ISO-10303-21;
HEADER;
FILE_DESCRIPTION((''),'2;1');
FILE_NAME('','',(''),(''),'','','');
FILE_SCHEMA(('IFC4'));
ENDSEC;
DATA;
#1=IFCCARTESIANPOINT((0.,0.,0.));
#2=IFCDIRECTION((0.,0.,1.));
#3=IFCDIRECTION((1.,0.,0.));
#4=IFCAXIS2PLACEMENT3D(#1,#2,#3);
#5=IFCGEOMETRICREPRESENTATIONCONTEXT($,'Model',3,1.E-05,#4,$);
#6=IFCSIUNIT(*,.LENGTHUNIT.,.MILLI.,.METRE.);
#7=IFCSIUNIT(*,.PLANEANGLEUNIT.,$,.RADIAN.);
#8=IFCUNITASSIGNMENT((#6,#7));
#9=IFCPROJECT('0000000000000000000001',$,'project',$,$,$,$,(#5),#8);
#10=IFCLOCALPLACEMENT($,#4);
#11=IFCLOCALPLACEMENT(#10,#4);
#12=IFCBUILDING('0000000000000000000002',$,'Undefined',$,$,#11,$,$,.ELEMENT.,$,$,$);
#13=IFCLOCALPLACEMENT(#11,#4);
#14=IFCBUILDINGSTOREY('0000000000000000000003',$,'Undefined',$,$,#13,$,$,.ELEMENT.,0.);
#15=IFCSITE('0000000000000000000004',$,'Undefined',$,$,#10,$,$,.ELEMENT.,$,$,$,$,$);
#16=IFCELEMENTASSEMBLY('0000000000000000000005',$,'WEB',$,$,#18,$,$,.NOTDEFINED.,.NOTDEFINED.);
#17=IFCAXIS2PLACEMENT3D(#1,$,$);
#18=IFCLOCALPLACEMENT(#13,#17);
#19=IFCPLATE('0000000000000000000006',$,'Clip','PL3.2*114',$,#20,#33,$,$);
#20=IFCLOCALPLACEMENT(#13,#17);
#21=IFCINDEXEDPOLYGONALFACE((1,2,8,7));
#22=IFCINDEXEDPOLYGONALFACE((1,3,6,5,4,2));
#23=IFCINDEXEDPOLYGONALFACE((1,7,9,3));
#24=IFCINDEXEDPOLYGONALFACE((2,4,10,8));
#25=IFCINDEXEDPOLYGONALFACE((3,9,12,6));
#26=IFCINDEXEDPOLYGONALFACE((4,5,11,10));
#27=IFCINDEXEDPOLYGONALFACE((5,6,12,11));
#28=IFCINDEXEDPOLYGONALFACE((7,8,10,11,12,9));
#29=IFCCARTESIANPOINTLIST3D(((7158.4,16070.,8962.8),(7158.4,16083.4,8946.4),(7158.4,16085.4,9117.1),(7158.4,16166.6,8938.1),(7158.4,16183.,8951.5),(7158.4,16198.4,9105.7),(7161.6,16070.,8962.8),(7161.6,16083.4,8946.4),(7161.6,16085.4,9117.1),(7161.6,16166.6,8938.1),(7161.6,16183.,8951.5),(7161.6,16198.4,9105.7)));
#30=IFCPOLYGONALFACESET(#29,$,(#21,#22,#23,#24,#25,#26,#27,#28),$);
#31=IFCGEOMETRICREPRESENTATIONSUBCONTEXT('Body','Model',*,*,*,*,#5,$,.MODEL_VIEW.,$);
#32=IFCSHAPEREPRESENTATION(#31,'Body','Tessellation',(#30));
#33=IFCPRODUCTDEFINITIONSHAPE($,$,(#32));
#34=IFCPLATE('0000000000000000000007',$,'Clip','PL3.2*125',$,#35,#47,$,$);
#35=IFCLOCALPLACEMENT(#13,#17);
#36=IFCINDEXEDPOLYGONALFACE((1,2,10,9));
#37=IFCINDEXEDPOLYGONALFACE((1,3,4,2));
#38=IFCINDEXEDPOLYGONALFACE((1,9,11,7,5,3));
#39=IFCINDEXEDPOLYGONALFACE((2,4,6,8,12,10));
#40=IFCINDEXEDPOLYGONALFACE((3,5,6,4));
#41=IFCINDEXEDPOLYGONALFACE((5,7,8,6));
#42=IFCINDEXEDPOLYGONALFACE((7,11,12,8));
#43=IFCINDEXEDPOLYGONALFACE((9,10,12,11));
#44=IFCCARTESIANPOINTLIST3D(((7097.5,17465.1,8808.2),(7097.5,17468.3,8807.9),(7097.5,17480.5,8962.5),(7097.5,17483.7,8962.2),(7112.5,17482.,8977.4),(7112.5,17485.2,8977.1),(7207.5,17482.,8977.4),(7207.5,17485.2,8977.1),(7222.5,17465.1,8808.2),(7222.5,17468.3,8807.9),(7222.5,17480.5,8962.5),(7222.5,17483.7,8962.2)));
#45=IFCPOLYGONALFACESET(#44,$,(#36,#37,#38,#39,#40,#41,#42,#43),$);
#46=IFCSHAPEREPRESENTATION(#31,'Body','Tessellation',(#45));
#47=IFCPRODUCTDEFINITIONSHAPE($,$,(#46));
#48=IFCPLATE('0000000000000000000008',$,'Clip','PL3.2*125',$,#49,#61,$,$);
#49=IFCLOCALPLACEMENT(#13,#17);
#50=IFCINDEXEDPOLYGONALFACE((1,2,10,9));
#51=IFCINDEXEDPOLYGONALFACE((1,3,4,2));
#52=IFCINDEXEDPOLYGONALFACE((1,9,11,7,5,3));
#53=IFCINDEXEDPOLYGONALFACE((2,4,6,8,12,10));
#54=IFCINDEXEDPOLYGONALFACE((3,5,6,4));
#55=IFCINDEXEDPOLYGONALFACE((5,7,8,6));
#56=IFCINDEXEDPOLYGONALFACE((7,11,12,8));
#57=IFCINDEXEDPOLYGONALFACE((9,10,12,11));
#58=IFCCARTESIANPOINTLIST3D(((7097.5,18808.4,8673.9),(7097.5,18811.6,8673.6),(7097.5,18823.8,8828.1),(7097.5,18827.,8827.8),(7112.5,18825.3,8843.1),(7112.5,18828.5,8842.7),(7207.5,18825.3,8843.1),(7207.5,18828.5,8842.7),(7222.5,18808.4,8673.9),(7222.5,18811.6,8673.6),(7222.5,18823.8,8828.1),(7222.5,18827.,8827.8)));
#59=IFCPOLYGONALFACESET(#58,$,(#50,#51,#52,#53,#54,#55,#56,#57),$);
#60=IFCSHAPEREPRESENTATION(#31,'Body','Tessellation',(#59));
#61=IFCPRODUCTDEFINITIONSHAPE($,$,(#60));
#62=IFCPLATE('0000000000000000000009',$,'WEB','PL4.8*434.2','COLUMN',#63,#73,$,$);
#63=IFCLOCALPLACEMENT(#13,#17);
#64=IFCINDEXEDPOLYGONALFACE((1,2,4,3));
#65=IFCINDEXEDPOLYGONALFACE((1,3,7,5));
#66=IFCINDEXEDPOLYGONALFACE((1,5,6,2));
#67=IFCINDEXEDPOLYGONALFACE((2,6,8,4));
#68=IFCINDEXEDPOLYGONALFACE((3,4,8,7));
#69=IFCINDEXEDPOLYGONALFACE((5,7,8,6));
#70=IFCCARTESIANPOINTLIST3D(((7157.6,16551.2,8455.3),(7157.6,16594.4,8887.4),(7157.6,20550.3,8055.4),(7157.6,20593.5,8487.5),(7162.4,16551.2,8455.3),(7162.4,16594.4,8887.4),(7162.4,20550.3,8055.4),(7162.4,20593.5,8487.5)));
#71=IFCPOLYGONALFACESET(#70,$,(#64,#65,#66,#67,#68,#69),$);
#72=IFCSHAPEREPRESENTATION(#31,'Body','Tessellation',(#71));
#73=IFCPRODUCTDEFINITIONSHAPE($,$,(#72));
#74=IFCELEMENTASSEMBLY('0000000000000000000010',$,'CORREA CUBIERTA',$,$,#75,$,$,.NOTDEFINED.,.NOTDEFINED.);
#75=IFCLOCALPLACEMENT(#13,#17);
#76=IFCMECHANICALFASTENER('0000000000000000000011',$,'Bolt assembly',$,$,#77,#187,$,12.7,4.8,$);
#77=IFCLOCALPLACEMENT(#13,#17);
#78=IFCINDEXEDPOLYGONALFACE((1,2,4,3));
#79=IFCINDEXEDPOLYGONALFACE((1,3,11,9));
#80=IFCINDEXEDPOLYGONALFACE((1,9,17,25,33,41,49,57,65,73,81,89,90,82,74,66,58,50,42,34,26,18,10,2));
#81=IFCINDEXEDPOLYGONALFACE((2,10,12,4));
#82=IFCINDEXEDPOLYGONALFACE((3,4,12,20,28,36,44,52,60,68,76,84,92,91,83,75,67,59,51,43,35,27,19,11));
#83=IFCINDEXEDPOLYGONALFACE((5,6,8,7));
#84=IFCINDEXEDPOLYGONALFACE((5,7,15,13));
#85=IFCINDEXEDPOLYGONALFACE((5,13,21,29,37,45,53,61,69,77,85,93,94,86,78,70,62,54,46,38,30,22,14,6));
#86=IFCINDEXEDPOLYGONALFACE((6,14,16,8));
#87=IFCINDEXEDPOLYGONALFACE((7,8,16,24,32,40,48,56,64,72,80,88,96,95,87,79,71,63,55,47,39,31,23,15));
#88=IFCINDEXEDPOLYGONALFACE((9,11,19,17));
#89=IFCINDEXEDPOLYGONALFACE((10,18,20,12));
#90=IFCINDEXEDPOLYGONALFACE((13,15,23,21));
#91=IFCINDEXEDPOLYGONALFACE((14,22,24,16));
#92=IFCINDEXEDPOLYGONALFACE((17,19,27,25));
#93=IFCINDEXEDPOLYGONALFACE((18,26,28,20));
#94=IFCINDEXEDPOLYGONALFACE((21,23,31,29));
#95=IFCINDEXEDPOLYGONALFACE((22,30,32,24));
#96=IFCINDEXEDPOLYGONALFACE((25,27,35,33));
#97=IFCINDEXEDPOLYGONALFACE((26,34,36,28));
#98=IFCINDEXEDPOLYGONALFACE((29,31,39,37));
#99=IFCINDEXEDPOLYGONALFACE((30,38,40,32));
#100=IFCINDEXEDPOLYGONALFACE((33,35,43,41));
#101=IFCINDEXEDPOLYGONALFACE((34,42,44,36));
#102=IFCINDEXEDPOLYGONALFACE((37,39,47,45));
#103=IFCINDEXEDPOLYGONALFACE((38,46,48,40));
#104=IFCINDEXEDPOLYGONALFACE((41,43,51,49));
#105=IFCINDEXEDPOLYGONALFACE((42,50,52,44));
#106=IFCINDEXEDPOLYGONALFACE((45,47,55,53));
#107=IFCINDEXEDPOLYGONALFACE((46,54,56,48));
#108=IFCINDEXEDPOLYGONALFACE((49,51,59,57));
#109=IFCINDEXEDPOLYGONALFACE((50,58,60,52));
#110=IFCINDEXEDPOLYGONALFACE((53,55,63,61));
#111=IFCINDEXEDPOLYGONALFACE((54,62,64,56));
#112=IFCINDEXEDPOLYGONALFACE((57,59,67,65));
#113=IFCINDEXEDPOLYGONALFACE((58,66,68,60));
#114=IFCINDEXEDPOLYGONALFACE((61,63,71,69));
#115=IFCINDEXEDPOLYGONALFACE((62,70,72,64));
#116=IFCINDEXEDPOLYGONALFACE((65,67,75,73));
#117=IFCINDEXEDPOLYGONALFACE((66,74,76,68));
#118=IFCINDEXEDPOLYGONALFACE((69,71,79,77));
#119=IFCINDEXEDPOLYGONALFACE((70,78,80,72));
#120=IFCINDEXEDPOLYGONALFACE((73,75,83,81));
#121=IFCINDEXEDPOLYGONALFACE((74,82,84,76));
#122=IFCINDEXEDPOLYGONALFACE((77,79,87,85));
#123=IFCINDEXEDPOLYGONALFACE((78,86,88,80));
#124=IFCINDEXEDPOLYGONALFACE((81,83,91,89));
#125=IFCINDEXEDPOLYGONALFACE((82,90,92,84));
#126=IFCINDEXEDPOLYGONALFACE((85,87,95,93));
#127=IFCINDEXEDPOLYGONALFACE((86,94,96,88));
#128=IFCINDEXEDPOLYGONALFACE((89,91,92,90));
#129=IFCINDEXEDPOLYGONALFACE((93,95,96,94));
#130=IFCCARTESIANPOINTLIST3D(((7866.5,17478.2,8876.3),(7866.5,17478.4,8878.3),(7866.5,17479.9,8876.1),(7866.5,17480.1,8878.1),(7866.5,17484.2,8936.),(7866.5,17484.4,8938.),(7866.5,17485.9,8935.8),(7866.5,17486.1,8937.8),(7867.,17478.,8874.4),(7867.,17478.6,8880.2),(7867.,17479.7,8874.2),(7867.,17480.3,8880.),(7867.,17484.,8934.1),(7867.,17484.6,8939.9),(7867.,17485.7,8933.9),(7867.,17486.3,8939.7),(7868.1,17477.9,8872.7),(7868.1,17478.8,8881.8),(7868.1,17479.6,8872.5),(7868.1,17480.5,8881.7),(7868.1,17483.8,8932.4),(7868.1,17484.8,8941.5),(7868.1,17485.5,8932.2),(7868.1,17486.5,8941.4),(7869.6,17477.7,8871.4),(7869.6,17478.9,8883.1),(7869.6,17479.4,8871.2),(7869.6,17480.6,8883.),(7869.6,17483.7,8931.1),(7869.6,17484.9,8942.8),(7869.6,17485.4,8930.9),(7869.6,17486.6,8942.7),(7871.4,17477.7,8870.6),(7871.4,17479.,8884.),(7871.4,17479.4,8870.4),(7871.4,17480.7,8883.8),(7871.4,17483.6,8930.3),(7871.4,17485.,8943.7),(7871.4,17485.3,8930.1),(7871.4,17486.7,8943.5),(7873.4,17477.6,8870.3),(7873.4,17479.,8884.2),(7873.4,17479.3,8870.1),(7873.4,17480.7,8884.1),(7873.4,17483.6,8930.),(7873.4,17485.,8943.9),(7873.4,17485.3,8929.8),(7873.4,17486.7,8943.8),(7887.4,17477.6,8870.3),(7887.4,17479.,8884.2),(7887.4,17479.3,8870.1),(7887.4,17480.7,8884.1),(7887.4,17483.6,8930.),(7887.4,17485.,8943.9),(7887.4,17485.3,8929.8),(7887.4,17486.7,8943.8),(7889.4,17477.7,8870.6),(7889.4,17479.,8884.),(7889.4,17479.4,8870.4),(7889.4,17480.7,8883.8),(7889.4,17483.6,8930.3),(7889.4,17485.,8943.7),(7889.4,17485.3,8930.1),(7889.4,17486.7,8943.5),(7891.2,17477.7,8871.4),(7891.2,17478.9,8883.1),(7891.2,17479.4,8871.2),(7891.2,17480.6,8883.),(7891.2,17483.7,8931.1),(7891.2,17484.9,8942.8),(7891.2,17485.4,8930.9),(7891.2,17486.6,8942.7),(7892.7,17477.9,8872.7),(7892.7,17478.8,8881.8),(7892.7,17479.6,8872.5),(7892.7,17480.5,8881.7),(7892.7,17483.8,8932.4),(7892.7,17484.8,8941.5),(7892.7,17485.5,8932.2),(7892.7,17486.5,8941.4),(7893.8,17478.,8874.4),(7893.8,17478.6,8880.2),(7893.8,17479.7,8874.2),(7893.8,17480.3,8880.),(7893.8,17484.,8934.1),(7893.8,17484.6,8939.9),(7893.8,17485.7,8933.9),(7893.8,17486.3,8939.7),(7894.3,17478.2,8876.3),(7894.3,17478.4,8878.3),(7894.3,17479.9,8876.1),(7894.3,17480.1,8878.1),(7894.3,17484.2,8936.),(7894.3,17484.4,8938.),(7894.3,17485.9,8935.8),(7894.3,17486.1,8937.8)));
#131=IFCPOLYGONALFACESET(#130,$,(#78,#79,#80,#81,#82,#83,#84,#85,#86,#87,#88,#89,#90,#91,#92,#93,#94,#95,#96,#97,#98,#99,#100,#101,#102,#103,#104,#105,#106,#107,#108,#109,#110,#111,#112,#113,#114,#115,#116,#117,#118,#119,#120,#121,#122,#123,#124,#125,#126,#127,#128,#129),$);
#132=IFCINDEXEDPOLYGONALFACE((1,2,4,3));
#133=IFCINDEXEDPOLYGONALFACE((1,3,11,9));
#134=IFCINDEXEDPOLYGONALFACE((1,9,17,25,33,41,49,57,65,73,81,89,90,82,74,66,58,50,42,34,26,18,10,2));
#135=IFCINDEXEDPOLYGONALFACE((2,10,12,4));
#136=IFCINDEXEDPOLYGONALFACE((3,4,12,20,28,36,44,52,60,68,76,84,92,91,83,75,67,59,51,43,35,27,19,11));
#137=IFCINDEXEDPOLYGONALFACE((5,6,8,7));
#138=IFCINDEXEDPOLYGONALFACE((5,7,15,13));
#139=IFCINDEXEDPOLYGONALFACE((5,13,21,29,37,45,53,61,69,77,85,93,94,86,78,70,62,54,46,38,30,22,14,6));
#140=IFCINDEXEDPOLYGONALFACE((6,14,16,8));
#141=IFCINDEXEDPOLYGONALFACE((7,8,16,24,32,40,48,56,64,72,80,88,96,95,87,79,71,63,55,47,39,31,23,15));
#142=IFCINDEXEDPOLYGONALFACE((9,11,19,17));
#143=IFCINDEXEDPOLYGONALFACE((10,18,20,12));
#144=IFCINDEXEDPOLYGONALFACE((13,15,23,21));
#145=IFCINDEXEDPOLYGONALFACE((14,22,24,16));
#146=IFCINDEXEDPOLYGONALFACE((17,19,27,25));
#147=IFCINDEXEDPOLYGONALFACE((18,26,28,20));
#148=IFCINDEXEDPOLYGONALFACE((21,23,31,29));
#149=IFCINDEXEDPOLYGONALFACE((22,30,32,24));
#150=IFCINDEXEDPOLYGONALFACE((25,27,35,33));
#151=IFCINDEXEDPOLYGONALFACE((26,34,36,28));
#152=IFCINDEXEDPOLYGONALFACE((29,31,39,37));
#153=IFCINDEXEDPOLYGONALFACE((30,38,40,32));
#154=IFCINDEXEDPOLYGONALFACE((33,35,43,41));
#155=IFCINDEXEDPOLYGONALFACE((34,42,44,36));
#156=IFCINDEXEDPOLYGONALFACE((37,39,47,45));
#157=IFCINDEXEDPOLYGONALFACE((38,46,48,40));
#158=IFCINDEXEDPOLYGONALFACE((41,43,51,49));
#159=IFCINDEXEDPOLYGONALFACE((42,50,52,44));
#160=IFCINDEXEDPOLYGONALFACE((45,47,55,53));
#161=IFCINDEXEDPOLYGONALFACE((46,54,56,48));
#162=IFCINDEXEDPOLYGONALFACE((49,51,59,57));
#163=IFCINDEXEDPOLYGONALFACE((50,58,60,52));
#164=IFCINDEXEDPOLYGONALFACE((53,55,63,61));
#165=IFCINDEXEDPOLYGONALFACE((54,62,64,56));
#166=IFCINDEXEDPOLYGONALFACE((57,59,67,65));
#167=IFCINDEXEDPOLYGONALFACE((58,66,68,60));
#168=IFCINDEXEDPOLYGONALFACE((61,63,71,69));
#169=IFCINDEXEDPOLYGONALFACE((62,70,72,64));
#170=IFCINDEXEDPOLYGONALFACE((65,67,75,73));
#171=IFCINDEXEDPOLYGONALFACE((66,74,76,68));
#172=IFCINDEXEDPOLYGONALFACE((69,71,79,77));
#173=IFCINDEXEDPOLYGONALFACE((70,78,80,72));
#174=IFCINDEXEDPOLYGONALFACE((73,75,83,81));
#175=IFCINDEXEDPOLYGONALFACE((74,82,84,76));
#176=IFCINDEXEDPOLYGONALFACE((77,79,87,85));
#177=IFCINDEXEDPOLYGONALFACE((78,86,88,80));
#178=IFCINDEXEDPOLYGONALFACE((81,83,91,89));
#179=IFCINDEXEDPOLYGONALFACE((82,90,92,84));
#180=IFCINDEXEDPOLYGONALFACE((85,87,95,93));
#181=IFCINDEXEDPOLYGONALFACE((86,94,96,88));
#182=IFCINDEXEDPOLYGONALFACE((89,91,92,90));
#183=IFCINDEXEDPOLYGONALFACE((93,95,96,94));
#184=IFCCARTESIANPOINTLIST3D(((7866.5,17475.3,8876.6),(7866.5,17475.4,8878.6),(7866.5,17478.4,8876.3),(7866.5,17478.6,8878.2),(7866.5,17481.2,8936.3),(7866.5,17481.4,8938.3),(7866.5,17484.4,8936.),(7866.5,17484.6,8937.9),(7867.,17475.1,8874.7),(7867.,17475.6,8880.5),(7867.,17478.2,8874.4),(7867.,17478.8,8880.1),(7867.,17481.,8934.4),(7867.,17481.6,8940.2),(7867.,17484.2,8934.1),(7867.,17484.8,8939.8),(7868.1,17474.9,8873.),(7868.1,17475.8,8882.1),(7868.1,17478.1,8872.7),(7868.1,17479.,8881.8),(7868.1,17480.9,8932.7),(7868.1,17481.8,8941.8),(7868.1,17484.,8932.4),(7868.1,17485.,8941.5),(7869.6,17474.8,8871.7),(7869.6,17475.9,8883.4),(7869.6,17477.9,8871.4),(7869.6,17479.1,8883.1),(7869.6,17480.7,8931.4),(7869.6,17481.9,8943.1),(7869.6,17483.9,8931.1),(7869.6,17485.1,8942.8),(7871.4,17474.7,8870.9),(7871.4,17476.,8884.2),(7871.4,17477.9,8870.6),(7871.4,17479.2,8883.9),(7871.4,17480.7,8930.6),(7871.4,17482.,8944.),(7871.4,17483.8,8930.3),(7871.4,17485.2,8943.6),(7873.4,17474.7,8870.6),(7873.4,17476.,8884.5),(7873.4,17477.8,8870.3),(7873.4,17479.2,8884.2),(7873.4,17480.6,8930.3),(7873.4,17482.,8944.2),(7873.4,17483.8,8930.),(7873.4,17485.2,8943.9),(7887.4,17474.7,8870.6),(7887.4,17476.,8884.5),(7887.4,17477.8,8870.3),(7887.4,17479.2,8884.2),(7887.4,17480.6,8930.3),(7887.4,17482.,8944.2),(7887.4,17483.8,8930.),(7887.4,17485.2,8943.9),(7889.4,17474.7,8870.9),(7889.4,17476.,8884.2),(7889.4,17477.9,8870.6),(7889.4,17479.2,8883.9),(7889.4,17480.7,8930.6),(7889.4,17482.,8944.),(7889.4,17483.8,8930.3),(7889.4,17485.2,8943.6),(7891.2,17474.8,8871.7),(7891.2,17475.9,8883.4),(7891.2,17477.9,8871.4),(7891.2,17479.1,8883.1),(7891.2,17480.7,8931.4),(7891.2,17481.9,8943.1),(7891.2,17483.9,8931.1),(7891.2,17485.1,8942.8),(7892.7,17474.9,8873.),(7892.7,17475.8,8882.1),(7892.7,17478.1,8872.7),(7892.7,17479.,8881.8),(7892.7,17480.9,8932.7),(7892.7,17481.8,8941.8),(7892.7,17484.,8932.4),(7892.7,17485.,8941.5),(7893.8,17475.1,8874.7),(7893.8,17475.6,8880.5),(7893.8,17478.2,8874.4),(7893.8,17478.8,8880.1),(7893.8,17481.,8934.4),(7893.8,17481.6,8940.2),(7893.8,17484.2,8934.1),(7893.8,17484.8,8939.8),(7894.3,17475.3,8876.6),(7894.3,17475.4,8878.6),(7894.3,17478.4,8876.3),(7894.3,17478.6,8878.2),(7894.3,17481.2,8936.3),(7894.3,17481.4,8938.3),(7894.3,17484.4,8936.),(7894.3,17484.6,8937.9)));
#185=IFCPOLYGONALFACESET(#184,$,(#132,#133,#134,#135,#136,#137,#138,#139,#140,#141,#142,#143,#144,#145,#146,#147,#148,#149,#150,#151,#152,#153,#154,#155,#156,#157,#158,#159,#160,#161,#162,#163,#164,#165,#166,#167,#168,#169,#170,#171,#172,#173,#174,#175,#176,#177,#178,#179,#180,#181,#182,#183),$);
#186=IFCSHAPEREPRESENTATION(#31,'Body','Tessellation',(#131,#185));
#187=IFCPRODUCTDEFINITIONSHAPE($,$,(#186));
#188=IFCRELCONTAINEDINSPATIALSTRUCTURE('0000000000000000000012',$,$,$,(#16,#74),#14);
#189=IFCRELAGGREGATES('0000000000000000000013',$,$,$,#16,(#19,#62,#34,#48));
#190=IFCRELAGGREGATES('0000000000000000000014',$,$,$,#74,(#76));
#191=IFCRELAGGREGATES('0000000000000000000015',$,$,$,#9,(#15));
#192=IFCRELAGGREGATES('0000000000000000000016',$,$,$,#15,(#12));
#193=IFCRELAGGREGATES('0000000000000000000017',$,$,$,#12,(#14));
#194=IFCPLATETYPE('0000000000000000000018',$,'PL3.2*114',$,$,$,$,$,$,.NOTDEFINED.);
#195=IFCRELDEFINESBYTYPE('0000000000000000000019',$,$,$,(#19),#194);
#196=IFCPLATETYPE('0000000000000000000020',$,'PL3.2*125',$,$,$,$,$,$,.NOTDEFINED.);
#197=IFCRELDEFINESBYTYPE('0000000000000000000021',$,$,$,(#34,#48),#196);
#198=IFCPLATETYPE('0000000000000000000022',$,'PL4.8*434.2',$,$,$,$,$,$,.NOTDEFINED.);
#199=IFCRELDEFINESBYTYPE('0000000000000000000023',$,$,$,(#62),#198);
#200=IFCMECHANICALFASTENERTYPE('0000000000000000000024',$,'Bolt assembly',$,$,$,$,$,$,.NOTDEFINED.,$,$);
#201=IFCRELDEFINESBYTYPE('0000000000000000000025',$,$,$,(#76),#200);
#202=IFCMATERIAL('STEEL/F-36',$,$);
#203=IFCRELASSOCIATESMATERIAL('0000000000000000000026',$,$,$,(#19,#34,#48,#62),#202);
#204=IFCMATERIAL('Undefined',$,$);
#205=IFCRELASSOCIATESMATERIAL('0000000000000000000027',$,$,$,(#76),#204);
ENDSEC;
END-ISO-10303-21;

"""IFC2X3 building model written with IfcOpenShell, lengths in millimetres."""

from ifc_helpers import new_model, entity, si_unit, frame, origin_with_axes, place, context, subcontext, project, spatial, polyline, outline, extrude, source, transform, mapped, material, type_object, element, aggregate, save


model = new_model("IFC2X3")

# Units and contexts
model_context = context("Model", 3, precision=1e-05, world=origin_with_axes())
body_context = subcontext(model_context, "Body", "Model", "MODEL_VIEW")
ifc_project = project(units=[si_unit("LENGTHUNIT", "METRE", prefix="MILLI"), si_unit("PLANEANGLEUNIT", "RADIAN")], contexts=[model_context])

# Site, building, storey
site_placement = place(None, origin_with_axes())
site = spatial("IfcSite", under=ifc_project, at=site_placement, Name="Undefined", CompositionType="ELEMENT")
building_placement = place(site_placement, origin_with_axes())
building = spatial("IfcBuilding", under=site, at=building_placement, Name="Undefined", CompositionType="ELEMENT")
storey_placement = place(building_placement, origin_with_axes())
storey = spatial("IfcBuildingStorey", under=building, at=storey_placement, Name="Undefined", CompositionType="ELEMENT", Elevation=0.0)

# Element assembly, plates
assembly_1_placement = place(storey_placement, origin_with_axes())
assembly_1 = element("IfcElementAssembly", 1, at=assembly_1_placement, inside=storey, Name="WEB", AssemblyPlace="NOTDEFINED", PredefinedType="NOTDEFINED")
ifc_material_1 = material(Name="STEEL/F-36")
plate_type_1 = type_object("IfcPlateType", Name="PL3.2*114", PredefinedType="NOTDEFINED")
plate_1_placement = place(assembly_1_placement, frame((7160.0, 16198.4, 9105.7), z_axis=(1.0, 0.0, 0.0), x_axis=(0.0, -0.995037, 0.099503)))
plate_1 = element("IfcPlate", 2, at=plate_1_placement, type_object=plate_type_1, material=ifc_material_1, Name="Clip", Description="PL3.2*114", context=body_context, shape_type="SweptSolid", body=[
    extrude(outline(polyline([(0.0, 0.0), (113.6, 0.0), (113.6, 155.0), (98.6, 170.0), (15.0, 170.0), (0.0, 155.0), (0.0, 0.0)])), frame((0.0, 0.0, -1.6), z_axis=(0.0, 0.0, 1.0), x_axis=(1.0, 0.0, 0.0)), (0.0, 0.0, 1.0), 3.2),
])
plate_type_2 = type_object("IfcPlateType", Name="PL3.2*125", PredefinedType="NOTDEFINED")
plate_2_placement = place(assembly_1_placement, frame((7222.5, 17466.7, 8808.1), z_axis=(0.0, 0.995037, -0.099504), x_axis=(-1.0, 0.0, 0.0)))
plate_2 = element("IfcPlate", 3, at=plate_2_placement, type_object=plate_type_2, material=ifc_material_1, Name="Clip", Description="PL3.2*125", context=body_context, shape_type="SweptSolid", body=[
    extrude(outline(polyline([(0.0, 0.0), (125.0, 0.0), (125.0, 155.0), (110.0, 170.0), (15.0, 170.0), (0.0, 155.0), (0.0, 0.0)])), frame((0.0, 0.0, -1.6), z_axis=(0.0, 0.0, 1.0), x_axis=(1.0, 0.0, 0.0)), (0.0, 0.0, 1.0), 3.2),
])
plate_3_placement = place(assembly_1_placement, frame((7222.5, 18810.0, 8673.8), z_axis=(0.0, 0.995037, -0.099504), x_axis=(-1.0, 0.0, 0.0)))
plate_3 = element("IfcPlate", 4, at=plate_3_placement, type_object=plate_type_2, material=ifc_material_1, Name="Clip", Description="PL3.2*125", context=body_context, shape_type="SweptSolid", body=[
    extrude(outline(polyline([(0.0, 0.0), (125.0, 0.0), (125.0, 155.0), (110.0, 170.0), (15.0, 170.0), (0.0, 155.0), (0.0, 0.0)])), frame((0.0, 0.0, -1.6), z_axis=(0.0, 0.0, 1.0), x_axis=(1.0, 0.0, 0.0)), (0.0, 0.0, 1.0), 3.2),
])
plate_type_3 = type_object("IfcPlateType", Name="PL4.8*434.2", PredefinedType="NOTDEFINED")
plate_4_placement = place(assembly_1_placement, frame((7160.0, 16572.8, 8671.3), z_axis=(-1.0, 0.0, 0.0), x_axis=(0.0, 0.995037, -0.099504)))
plate_4 = element("IfcPlate", 5, at=plate_4_placement, type_object=plate_type_3, material=ifc_material_1, Name="WEB", Description="PL4.8*434.2", ObjectType="COLUMN", context=body_context, shape_type="SweptSolid", body=[
    extrude(outline(polyline([(0.0, -217.1), (0.0, 217.1), (4019.1, 217.1), (4019.1, -217.1), (0.0, -217.1)])), frame((0.0, 0.0, -2.4), z_axis=(0.0, 0.0, 1.0), x_axis=(1.0, 0.0, 0.0)), (0.0, 0.0, 1.0), 4.8),
])

# Element assembly, mechanical fastener
ifc_material_2 = material(Name="Undefined")
mechanical_fastener_type = type_object("IfcMechanicalFastenerType", Name="Bolt assembly")
assembly_2_placement = place(storey_placement, origin_with_axes())
assembly_2 = element("IfcElementAssembly", 6, at=assembly_2_placement, inside=storey, Name="CORREA CUBIERTA", AssemblyPlace="NOTDEFINED", PredefinedType="NOTDEFINED")
shared_circle_1 = entity("IfcCircle", entity("IfcAxis2Placement2D", entity("IfcCartesianPoint", [0.0, -7.0]), entity("IfcDirection", [1.0, 0.0])), 7.0)
shared_circle_2 = entity("IfcCircle", entity("IfcAxis2Placement2D", entity("IfcCartesianPoint", [0.0, 7.0]), entity("IfcDirection", [-1.0, 0.0])), 7.0)
shared_composite_curve = entity("IfcCompositeCurve", [entity("IfcCompositeCurveSegment", "CONTINUOUS", True, entity("IfcPolyline", [entity("IfcCartesianPoint", [7.0, 7.0]), entity("IfcCartesianPoint", [7.0, -7.0])])), entity("IfcCompositeCurveSegment", "CONTINUOUS", True, entity("IfcTrimmedCurve", shared_circle_1, [entity("IfcParameterValue", 0.0)], [entity("IfcParameterValue", 3.141593)], False, "PARAMETER")), entity("IfcCompositeCurveSegment", "CONTINUOUS", True, entity("IfcPolyline", [entity("IfcCartesianPoint", [-7.0, -7.0]), entity("IfcCartesianPoint", [-7.0, 7.0])])), entity("IfcCompositeCurveSegment", "DISCONTINUOUS", True, entity("IfcTrimmedCurve", shared_circle_2, [entity("IfcParameterValue", 0.0)], [entity("IfcParameterValue", 3.141593)], False, "PARAMETER"))], False)
shared_shape_1 = source(origin_with_axes(), body_context, "Body", "SweptSolid", [
    entity("IfcExtrudedAreaSolid", entity("IfcArbitraryClosedProfileDef", "AREA", None, shared_composite_curve), entity("IfcAxis2Placement3D", entity("IfcCartesianPoint", [0.0, 3.1, 0.0]), entity("IfcDirection", [0.0, 1.0, 0.0]), entity("IfcDirection", [1.0, 0.0, 0.0])), entity("IfcDirection", [0.0, 0.0, 1.0]), 1.7),
    entity("IfcExtrudedAreaSolid", entity("IfcArbitraryClosedProfileDef", "AREA", None, shared_composite_curve), entity("IfcAxis2Placement3D", entity("IfcCartesianPoint", [0.0, 0.1, 0.0]), entity("IfcDirection", [0.0, 1.0, 0.0]), entity("IfcDirection", [1.0, 0.0, 0.0])), entity("IfcDirection", [0.0, 0.0, 1.0]), 3.2),
])
mechanical_fastener_1_placement = place(assembly_2_placement, frame((7880.4, 17481.2, 8937.3), z_axis=(1.0, 0.0, 0.0), x_axis=(0.0, -0.099503, -0.995037)))
mechanical_fastener_1 = element("IfcMechanicalFastener", 7, at=mechanical_fastener_1_placement, type_object=mechanical_fastener_type, material=ifc_material_2, Name="Bolt assembly", NominalDiameter=12.7, NominalLength=4.8, context=body_context, shape_type="MappedRepresentation", body=[
    mapped(shared_shape_1, transform((0.0, 0.0, 0.0))),
    mapped(shared_shape_1, transform((60.0, 0.0, 0.0))),
])

aggregate(assembly_1, [plate_1, plate_4, plate_2, plate_3])

aggregate(assembly_2, [mechanical_fastener_1])

save(model, "model.ifc")
